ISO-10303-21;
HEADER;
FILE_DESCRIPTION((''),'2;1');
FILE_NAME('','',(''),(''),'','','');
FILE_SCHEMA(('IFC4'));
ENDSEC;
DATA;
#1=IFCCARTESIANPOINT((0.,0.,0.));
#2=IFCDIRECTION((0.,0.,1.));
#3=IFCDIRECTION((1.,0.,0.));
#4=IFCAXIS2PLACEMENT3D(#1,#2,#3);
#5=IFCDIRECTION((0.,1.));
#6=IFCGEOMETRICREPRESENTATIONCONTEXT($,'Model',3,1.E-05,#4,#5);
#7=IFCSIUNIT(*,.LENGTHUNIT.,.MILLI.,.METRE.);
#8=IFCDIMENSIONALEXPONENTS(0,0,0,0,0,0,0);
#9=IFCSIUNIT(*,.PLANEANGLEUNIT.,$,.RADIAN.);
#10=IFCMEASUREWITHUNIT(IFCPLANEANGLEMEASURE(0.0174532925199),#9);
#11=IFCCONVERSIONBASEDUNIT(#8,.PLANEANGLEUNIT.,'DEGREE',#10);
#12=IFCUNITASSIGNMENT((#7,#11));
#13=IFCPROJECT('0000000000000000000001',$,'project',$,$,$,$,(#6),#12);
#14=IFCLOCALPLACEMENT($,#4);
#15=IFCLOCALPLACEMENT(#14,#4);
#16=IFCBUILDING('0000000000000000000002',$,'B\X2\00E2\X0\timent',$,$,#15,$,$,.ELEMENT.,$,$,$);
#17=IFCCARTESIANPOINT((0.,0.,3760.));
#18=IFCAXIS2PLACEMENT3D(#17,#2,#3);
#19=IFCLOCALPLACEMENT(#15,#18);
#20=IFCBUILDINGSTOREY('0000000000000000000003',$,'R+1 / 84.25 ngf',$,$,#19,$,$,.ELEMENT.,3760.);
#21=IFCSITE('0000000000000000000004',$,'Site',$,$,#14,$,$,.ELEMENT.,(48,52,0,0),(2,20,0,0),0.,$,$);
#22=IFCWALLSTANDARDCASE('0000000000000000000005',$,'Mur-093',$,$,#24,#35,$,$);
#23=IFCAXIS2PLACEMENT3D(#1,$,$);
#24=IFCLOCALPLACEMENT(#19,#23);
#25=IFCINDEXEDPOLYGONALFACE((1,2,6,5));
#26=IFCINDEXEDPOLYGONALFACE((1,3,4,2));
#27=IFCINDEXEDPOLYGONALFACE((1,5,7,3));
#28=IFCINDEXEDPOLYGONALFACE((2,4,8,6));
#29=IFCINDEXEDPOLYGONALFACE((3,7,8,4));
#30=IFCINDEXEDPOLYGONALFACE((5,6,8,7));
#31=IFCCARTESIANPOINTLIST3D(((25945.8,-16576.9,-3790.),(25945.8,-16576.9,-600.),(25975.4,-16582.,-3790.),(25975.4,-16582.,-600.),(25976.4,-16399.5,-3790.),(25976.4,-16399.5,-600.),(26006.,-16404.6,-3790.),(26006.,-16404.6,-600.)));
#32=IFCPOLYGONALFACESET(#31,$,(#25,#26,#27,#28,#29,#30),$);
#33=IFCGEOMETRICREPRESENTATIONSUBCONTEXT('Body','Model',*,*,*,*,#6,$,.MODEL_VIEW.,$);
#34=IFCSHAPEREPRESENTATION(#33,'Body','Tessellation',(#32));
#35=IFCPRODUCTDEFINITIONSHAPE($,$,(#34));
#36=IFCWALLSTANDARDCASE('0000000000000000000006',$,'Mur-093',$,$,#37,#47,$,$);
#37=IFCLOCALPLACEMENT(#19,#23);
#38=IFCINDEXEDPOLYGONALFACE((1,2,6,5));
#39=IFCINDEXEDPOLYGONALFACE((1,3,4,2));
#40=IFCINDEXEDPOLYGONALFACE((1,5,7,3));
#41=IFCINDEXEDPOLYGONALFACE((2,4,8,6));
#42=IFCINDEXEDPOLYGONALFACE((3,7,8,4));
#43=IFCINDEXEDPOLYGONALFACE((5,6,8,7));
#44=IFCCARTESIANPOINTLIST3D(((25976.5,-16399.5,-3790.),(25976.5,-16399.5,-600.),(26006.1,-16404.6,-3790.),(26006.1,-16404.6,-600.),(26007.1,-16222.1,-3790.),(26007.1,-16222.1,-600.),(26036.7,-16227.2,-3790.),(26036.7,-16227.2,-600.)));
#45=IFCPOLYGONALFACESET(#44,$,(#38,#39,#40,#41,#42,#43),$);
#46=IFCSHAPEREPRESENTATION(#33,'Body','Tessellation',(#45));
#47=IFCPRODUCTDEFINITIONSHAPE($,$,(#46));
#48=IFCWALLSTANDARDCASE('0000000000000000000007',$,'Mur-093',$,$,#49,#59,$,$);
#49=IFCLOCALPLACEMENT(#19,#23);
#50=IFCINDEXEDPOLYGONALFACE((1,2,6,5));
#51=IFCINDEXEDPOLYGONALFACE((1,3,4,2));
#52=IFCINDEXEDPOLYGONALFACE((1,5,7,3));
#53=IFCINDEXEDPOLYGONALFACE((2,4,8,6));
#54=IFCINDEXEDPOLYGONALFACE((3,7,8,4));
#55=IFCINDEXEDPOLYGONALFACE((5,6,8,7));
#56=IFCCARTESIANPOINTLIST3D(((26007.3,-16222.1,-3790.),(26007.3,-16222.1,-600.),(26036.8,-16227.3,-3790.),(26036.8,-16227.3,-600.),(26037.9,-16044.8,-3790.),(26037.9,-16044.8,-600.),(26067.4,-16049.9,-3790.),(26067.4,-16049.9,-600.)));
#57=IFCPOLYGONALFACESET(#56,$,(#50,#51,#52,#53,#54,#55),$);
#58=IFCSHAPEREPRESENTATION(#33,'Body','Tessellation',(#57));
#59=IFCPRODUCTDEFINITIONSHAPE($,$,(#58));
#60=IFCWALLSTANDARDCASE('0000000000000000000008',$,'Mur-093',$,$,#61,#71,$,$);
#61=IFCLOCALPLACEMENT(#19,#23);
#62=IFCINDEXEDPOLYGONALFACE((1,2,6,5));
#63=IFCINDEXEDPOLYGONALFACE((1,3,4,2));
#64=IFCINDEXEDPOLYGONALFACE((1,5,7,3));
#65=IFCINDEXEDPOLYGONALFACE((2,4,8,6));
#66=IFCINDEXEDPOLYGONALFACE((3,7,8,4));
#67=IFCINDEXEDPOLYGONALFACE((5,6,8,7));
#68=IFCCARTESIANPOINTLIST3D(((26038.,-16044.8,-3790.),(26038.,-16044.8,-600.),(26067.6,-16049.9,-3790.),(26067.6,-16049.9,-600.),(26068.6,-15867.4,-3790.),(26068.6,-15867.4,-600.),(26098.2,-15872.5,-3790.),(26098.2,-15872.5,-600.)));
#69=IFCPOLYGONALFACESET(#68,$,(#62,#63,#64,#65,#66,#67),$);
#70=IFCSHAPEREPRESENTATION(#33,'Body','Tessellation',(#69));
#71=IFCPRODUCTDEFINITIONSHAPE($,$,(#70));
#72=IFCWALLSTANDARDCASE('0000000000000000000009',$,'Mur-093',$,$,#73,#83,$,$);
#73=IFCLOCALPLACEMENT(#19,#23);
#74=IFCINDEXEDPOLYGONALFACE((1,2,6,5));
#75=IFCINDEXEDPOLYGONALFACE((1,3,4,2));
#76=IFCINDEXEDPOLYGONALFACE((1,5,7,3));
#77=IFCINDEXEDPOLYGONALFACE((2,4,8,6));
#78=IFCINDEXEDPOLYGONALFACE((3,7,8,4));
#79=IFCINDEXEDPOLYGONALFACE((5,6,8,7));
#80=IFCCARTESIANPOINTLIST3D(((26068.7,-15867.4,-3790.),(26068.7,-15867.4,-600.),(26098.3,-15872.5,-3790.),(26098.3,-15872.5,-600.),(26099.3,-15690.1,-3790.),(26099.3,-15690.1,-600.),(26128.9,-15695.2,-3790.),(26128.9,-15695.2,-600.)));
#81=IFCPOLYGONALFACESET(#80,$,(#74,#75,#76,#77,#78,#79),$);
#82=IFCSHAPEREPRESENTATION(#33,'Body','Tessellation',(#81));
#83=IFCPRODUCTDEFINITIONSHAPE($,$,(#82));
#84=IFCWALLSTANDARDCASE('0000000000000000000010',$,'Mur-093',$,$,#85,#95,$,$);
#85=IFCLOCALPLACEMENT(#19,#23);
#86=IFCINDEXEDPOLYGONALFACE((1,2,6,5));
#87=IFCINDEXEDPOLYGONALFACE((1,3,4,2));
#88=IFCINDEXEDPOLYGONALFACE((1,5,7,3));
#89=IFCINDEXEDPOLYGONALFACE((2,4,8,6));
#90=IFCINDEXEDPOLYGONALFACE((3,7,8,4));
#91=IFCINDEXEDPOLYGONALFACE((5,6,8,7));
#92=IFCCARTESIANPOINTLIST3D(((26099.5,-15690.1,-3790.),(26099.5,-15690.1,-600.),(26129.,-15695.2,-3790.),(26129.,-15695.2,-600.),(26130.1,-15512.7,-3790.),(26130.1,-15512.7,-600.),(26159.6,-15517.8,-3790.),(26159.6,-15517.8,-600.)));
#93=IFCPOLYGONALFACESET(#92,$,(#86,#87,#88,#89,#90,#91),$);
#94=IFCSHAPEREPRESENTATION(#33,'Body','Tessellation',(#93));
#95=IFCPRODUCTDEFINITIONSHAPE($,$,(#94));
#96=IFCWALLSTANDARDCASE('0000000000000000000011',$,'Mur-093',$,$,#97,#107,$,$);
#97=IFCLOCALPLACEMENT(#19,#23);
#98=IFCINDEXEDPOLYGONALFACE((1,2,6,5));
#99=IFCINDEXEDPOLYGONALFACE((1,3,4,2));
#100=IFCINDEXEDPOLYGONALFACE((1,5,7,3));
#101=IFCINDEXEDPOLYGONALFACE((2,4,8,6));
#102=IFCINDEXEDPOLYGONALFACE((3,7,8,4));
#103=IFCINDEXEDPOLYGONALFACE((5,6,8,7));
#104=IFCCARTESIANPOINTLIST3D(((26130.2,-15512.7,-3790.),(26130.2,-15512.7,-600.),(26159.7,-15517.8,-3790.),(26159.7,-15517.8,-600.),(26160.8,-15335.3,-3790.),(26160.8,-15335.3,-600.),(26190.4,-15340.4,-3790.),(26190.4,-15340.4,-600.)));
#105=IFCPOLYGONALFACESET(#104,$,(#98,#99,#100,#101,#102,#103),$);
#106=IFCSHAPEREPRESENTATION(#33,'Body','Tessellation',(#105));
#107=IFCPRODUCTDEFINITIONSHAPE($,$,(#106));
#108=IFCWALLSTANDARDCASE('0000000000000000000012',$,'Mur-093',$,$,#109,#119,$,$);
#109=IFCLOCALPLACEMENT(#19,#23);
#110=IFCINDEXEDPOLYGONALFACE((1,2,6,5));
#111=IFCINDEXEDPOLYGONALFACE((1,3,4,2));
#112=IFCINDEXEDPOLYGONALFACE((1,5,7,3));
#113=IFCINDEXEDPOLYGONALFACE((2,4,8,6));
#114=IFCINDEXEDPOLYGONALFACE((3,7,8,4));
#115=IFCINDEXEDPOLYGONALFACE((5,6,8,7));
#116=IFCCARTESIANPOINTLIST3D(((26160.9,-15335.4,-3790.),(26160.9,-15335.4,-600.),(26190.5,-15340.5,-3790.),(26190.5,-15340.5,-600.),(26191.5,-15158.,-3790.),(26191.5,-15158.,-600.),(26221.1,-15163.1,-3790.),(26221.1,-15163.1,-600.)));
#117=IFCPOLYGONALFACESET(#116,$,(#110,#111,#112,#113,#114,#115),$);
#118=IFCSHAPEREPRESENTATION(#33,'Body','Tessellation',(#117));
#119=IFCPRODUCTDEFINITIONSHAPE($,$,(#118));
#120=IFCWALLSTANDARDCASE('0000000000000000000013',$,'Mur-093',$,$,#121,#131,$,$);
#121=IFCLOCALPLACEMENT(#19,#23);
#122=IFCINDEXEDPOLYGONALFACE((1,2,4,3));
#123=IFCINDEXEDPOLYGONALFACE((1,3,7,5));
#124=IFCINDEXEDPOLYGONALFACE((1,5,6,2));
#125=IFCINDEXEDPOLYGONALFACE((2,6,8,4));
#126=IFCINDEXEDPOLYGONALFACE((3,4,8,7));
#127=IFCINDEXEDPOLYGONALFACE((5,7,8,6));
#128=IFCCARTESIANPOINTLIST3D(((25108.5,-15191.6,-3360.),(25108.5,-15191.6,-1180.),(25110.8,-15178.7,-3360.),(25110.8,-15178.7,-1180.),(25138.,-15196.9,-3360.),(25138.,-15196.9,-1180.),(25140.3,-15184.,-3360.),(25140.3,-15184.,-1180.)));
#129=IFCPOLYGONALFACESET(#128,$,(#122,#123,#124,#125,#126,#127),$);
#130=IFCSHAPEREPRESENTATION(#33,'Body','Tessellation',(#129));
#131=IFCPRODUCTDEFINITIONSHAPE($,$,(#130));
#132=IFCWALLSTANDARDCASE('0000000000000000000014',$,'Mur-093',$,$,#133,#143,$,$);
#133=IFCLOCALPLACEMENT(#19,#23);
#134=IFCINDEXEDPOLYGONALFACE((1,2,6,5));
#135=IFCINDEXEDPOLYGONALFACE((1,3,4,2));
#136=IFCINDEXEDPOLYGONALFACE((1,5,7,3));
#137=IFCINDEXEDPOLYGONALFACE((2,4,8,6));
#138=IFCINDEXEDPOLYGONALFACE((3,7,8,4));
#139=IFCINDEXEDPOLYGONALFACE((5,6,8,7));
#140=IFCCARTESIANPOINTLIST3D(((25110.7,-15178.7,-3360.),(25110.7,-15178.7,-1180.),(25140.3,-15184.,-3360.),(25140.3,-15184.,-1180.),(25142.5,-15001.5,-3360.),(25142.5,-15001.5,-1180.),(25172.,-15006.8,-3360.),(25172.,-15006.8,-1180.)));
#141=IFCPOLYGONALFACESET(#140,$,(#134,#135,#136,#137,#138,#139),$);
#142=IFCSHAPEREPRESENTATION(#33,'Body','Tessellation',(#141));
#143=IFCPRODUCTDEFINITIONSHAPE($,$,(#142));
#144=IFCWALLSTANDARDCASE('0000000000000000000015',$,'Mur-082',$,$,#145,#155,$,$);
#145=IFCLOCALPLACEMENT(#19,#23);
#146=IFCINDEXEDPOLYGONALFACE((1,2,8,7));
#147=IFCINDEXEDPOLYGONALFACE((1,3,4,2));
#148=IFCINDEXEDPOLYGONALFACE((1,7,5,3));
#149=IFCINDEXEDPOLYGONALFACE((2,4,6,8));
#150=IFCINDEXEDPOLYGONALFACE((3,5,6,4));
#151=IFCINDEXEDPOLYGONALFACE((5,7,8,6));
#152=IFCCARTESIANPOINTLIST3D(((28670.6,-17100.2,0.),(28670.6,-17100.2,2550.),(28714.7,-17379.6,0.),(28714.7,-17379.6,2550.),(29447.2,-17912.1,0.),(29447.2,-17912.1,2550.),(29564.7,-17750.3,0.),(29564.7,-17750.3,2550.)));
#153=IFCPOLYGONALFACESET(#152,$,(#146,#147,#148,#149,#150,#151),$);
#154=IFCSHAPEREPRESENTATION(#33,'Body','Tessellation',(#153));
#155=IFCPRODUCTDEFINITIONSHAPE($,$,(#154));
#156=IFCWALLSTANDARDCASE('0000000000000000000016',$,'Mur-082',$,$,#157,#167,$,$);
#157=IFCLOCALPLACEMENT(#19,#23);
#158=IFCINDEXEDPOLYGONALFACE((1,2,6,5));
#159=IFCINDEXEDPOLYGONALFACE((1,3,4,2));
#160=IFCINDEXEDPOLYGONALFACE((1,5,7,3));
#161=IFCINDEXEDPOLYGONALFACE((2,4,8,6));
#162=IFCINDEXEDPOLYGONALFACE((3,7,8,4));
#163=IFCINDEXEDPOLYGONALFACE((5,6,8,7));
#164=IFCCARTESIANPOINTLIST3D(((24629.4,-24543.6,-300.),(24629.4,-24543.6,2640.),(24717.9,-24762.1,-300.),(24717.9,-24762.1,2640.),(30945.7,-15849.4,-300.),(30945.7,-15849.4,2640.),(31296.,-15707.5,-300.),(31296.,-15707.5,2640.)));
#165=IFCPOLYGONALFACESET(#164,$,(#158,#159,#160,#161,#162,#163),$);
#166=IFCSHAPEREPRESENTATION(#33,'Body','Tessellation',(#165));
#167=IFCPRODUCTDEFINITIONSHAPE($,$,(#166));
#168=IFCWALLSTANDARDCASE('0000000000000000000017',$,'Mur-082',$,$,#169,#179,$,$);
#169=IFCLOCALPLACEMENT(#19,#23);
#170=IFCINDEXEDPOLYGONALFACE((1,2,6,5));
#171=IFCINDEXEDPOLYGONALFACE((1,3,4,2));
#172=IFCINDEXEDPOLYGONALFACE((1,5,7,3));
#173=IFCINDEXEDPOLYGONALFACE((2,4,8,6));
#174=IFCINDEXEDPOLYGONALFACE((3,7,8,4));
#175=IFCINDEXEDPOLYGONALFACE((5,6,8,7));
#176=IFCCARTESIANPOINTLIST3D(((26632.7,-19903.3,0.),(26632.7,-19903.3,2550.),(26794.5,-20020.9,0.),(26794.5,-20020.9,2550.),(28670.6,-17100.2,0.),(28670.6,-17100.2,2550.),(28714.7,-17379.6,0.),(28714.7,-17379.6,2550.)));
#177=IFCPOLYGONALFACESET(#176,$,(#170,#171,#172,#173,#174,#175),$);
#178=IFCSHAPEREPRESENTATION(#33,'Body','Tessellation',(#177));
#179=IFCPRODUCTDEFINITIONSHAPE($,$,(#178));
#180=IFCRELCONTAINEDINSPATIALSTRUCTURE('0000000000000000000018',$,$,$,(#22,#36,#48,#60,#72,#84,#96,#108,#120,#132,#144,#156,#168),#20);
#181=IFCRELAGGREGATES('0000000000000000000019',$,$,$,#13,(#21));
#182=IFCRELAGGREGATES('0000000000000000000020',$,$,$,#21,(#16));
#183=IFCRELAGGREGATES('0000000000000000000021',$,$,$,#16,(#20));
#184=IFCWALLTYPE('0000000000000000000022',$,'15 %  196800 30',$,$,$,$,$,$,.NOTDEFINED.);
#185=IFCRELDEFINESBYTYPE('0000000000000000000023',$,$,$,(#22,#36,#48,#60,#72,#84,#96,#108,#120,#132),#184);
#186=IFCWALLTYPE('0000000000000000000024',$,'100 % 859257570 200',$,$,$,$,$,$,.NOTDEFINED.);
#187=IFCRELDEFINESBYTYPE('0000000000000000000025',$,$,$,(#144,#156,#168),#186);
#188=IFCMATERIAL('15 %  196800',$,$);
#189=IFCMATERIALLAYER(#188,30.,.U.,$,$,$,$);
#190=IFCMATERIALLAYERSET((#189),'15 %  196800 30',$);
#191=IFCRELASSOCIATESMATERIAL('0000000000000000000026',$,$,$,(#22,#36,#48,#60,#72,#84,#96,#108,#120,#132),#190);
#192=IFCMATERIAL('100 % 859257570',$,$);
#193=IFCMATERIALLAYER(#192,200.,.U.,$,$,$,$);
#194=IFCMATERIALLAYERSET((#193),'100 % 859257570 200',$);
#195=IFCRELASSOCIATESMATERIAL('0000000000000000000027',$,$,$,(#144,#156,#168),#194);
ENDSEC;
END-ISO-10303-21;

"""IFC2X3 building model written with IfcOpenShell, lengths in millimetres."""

from ifc_helpers import new_model, entity, si_unit, converted_unit, direction, frame, origin_with_axes, place, context, subcontext, project, spatial, polyline, outline, extrude, material, layer, layer_set, layer_usage, type_object, element, save


model = new_model("IFC2X3")

# Units and contexts
model_context = context("Model", 3, precision=1e-05, world=origin_with_axes(), true_north=direction((0.0, 1.0)))
body_context = subcontext(model_context, "Body", "Model", "MODEL_VIEW")
ifc_project = project(units=[si_unit("LENGTHUNIT", "METRE", prefix="MILLI"), converted_unit("PLANEANGLEUNIT", "DEGREE", entity("IfcPlaneAngleMeasure", 0.0174532925199), si_unit("PLANEANGLEUNIT", "RADIAN"), dimensions=[0, 0, 0, 0, 0, 0, 0])], contexts=[model_context])

# Site, building, storey
site_placement = place(None, origin_with_axes())
site = spatial("IfcSite", under=ifc_project, at=site_placement, Name="Site", CompositionType="ELEMENT", RefLatitude=(48, 52, 0, 0), RefLongitude=(2, 20, 0, 0), RefElevation=0.0)
building_placement = place(site_placement, origin_with_axes())
building = spatial("IfcBuilding", under=site, at=building_placement, Name="Bâtiment", CompositionType="ELEMENT")
storey_placement = place(building_placement, frame((0.0, 0.0, 3760.0), z_axis=(0.0, 0.0, 1.0), x_axis=(1.0, 0.0, 0.0)))
storey = spatial("IfcBuildingStorey", under=building, at=storey_placement, Name="R+1 / 84.25 ngf", CompositionType="ELEMENT", Elevation=3760.0)

# Shared definitions
ifc_material_1 = material(Name="15 %  196800")

# Walls
ifc_layer_1 = layer(ifc_material_1, 30.0, ventilated="UNKNOWN")
ifc_layer_set_1 = layer_set([ifc_layer_1], Name="15 %  196800 30")
wall_type_1 = type_object("IfcWallType", Name="15 %  196800 30", PredefinedType="NOTDEFINED")
ifc_layer_usage_1 = layer_usage(ifc_layer_set_1, "AXIS2", "NEGATIVE", 30.0)
wall_1_placement = place(storey_placement, frame((25976.4, -16399.5, -3790.0), z_axis=(0.0, 0.0, 1.0), x_axis=(-0.170069, -0.985432, 0.0)))
element("IfcWallStandardCase", 1, at=wall_1_placement, inside=storey, type_object=wall_type_1, material=ifc_layer_usage_1, Name="Mur-093", context=body_context, shape_type="SweptSolid", body=[
    extrude(outline(polyline([(0.0, 0.0), (180.0, 0.0), (180.0, 30.0), (0.0, 30.0), (0.0, 0.0)])), origin_with_axes(), (0.0, 0.0, 1.0), 3190.0),
])
ifc_layer_usage_2 = layer_usage(ifc_layer_set_1, "AXIS2", "NEGATIVE", 30.0)
wall_2_placement = place(storey_placement, frame((26007.1, -16222.1, -3790.0), z_axis=(0.0, 0.0, 1.0), x_axis=(-0.170069, -0.985432, 0.0)))
element("IfcWallStandardCase", 2, at=wall_2_placement, inside=storey, type_object=wall_type_1, material=ifc_layer_usage_2, Name="Mur-093", context=body_context, shape_type="SweptSolid", body=[
    extrude(outline(polyline([(0.0, 0.0), (180.0, 0.0), (180.0, 30.0), (0.0, 30.0), (0.0, 0.0)])), origin_with_axes(), (0.0, 0.0, 1.0), 3190.0),
])
ifc_layer_usage_3 = layer_usage(ifc_layer_set_1, "AXIS2", "NEGATIVE", 30.0)
wall_3_placement = place(storey_placement, frame((26037.9, -16044.8, -3790.0), z_axis=(0.0, 0.0, 1.0), x_axis=(-0.170069, -0.985432, 0.0)))
element("IfcWallStandardCase", 3, at=wall_3_placement, inside=storey, type_object=wall_type_1, material=ifc_layer_usage_3, Name="Mur-093", context=body_context, shape_type="SweptSolid", body=[
    extrude(outline(polyline([(0.0, 0.0), (180.0, 0.0), (180.0, 30.0), (0.0, 30.0), (0.0, 0.0)])), origin_with_axes(), (0.0, 0.0, 1.0), 3190.0),
])
ifc_layer_usage_4 = layer_usage(ifc_layer_set_1, "AXIS2", "NEGATIVE", 30.0)
wall_4_placement = place(storey_placement, frame((26068.6, -15867.4, -3790.0), z_axis=(0.0, 0.0, 1.0), x_axis=(-0.170069, -0.985432, 0.0)))
element("IfcWallStandardCase", 4, at=wall_4_placement, inside=storey, type_object=wall_type_1, material=ifc_layer_usage_4, Name="Mur-093", context=body_context, shape_type="SweptSolid", body=[
    extrude(outline(polyline([(0.0, 0.0), (180.0, 0.0), (180.0, 30.0), (0.0, 30.0), (0.0, 0.0)])), origin_with_axes(), (0.0, 0.0, 1.0), 3190.0),
])
ifc_layer_usage_5 = layer_usage(ifc_layer_set_1, "AXIS2", "NEGATIVE", 30.0)
wall_5_placement = place(storey_placement, frame((26099.3, -15690.1, -3790.0), z_axis=(0.0, 0.0, 1.0), x_axis=(-0.170069, -0.985432, 0.0)))
element("IfcWallStandardCase", 5, at=wall_5_placement, inside=storey, type_object=wall_type_1, material=ifc_layer_usage_5, Name="Mur-093", context=body_context, shape_type="SweptSolid", body=[
    extrude(outline(polyline([(0.0, 0.0), (180.0, 0.0), (180.0, 30.0), (0.0, 30.0), (0.0, 0.0)])), origin_with_axes(), (0.0, 0.0, 1.0), 3190.0),
])
ifc_layer_usage_6 = layer_usage(ifc_layer_set_1, "AXIS2", "NEGATIVE", 30.0)
wall_6_placement = place(storey_placement, frame((26130.1, -15512.7, -3790.0), z_axis=(0.0, 0.0, 1.0), x_axis=(-0.170069, -0.985432, 0.0)))
element("IfcWallStandardCase", 6, at=wall_6_placement, inside=storey, type_object=wall_type_1, material=ifc_layer_usage_6, Name="Mur-093", context=body_context, shape_type="SweptSolid", body=[
    extrude(outline(polyline([(0.0, 0.0), (180.0, 0.0), (180.0, 30.0), (0.0, 30.0), (0.0, 0.0)])), origin_with_axes(), (0.0, 0.0, 1.0), 3190.0),
])
ifc_layer_usage_7 = layer_usage(ifc_layer_set_1, "AXIS2", "NEGATIVE", 30.0)
wall_7_placement = place(storey_placement, frame((26160.8, -15335.3, -3790.0), z_axis=(0.0, 0.0, 1.0), x_axis=(-0.170069, -0.985432, 0.0)))
element("IfcWallStandardCase", 7, at=wall_7_placement, inside=storey, type_object=wall_type_1, material=ifc_layer_usage_7, Name="Mur-093", context=body_context, shape_type="SweptSolid", body=[
    extrude(outline(polyline([(0.0, 0.0), (180.0, 0.0), (180.0, 30.0), (0.0, 30.0), (0.0, 0.0)])), origin_with_axes(), (0.0, 0.0, 1.0), 3190.0),
])
ifc_layer_usage_8 = layer_usage(ifc_layer_set_1, "AXIS2", "NEGATIVE", 30.0)
wall_8_placement = place(storey_placement, frame((26191.5, -15158.0, -3790.0), z_axis=(0.0, 0.0, 1.0), x_axis=(-0.170069, -0.985432, 0.0)))
element("IfcWallStandardCase", 8, at=wall_8_placement, inside=storey, type_object=wall_type_1, material=ifc_layer_usage_8, Name="Mur-093", context=body_context, shape_type="SweptSolid", body=[
    extrude(outline(polyline([(0.0, 0.0), (180.0, 0.0), (180.0, 30.0), (0.0, 30.0), (0.0, 0.0)])), origin_with_axes(), (0.0, 0.0, 1.0), 3190.0),
])
ifc_layer_usage_9 = layer_usage(ifc_layer_set_1, "AXIS2", "NEGATIVE", 30.0)
wall_9_placement = place(storey_placement, frame((25110.8, -15178.7, -3360.0), z_axis=(0.0, 0.0, 1.0), x_axis=(-0.176462, -0.984308, 0.0)))
element("IfcWallStandardCase", 9, at=wall_9_placement, inside=storey, type_object=wall_type_1, material=ifc_layer_usage_9, Name="Mur-093", context=body_context, shape_type="SweptSolid", body=[
    extrude(outline(polyline([(0.0, 0.0), (13.1, 0.0), (13.1, 30.0), (0.0, 30.0), (0.0, 0.0)])), origin_with_axes(), (0.0, 0.0, 1.0), 2180.0),
])
ifc_layer_usage_10 = layer_usage(ifc_layer_set_1, "AXIS2", "NEGATIVE", 30.0)
wall_10_placement = place(storey_placement, frame((25142.5, -15001.5, -3360.0), z_axis=(0.0, 0.0, 1.0), x_axis=(-0.176462, -0.984308, 0.0)))
element("IfcWallStandardCase", 10, at=wall_10_placement, inside=storey, type_object=wall_type_1, material=ifc_layer_usage_10, Name="Mur-093", context=body_context, shape_type="SweptSolid", body=[
    extrude(outline(polyline([(0.0, 0.0), (180.0, 0.0), (180.0, 30.0), (0.0, 30.0), (0.0, 0.0)])), origin_with_axes(), (0.0, 0.0, 1.0), 2180.0),
])
ifc_material_2 = material(Name="100 % 859257570")
ifc_layer_2 = layer(ifc_material_2, 200.0, ventilated="UNKNOWN")
ifc_layer_set_2 = layer_set([ifc_layer_2], Name="100 % 859257570 200")
ifc_layer_usage_11 = layer_usage(ifc_layer_set_2, "AXIS2", "POSITIVE", -200.0)
wall_type_2 = type_object("IfcWallType", Name="100 % 859257570 200", PredefinedType="NOTDEFINED")
wall_11_placement = place(storey_placement, frame((28832.3, -17217.8, 0.0), z_axis=(0.0, 0.0, 1.0), x_axis=(0.808824, -0.588051, 0.0)))
element("IfcWallStandardCase", 11, at=wall_11_placement, inside=storey, type_object=wall_type_2, material=ifc_layer_usage_11, Name="Mur-082", context=body_context, shape_type="SweptSolid", body=[
    extrude(outline(polyline([(0.0, -200.0), (905.6, -200.0), (905.5, 0.0), (-200.0, 0.0), (0.0, -200.0)])), origin_with_axes(), (0.0, 0.0, 1.0), 2550.0),
])
ifc_layer_usage_12 = layer_usage(ifc_layer_set_2, "AXIS2", "POSITIVE", -200.0)
wall_12_placement = place(storey_placement, frame((31296.0, -15707.5, -300.0), z_axis=(0.0, 0.0, 1.0), x_axis=(-0.587762, -0.809034, 0.0)))
element("IfcWallStandardCase", 12, at=wall_12_placement, inside=storey, type_object=wall_type_2, material=ifc_layer_usage_12, Name="Mur-082", context=body_context, shape_type="SweptSolid", body=[
    extrude(outline(polyline([(320.7, -200.0), (11067.0, -200.0), (11191.9, 0.0), (0.0, 0.0), (320.7, -200.0)])), origin_with_axes(), (0.0, 0.0, 1.0), 2940.0),
])
ifc_layer_usage_13 = layer_usage(ifc_layer_set_2, "AXIS2", "POSITIVE", -200.0)
wall_13_placement = place(storey_placement, frame((28832.3, -17217.8, 0.0), z_axis=(0.0, 0.0, 1.0), x_axis=(-0.588027, -0.808841, 0.0)))
element("IfcWallStandardCase", 13, at=wall_13_placement, inside=storey, type_object=wall_type_2, material=ifc_layer_usage_13, Name="Mur-082", context=body_context, shape_type="SweptSolid", body=[
    extrude(outline(polyline([(0.0, -200.0), (3465.6, -200.0), (3465.6, 0.0), (200.0, 0.0), (0.0, -200.0)])), origin_with_axes(), (0.0, 0.0, 1.0), 2550.0),
])

save(model, "model.ifc")
